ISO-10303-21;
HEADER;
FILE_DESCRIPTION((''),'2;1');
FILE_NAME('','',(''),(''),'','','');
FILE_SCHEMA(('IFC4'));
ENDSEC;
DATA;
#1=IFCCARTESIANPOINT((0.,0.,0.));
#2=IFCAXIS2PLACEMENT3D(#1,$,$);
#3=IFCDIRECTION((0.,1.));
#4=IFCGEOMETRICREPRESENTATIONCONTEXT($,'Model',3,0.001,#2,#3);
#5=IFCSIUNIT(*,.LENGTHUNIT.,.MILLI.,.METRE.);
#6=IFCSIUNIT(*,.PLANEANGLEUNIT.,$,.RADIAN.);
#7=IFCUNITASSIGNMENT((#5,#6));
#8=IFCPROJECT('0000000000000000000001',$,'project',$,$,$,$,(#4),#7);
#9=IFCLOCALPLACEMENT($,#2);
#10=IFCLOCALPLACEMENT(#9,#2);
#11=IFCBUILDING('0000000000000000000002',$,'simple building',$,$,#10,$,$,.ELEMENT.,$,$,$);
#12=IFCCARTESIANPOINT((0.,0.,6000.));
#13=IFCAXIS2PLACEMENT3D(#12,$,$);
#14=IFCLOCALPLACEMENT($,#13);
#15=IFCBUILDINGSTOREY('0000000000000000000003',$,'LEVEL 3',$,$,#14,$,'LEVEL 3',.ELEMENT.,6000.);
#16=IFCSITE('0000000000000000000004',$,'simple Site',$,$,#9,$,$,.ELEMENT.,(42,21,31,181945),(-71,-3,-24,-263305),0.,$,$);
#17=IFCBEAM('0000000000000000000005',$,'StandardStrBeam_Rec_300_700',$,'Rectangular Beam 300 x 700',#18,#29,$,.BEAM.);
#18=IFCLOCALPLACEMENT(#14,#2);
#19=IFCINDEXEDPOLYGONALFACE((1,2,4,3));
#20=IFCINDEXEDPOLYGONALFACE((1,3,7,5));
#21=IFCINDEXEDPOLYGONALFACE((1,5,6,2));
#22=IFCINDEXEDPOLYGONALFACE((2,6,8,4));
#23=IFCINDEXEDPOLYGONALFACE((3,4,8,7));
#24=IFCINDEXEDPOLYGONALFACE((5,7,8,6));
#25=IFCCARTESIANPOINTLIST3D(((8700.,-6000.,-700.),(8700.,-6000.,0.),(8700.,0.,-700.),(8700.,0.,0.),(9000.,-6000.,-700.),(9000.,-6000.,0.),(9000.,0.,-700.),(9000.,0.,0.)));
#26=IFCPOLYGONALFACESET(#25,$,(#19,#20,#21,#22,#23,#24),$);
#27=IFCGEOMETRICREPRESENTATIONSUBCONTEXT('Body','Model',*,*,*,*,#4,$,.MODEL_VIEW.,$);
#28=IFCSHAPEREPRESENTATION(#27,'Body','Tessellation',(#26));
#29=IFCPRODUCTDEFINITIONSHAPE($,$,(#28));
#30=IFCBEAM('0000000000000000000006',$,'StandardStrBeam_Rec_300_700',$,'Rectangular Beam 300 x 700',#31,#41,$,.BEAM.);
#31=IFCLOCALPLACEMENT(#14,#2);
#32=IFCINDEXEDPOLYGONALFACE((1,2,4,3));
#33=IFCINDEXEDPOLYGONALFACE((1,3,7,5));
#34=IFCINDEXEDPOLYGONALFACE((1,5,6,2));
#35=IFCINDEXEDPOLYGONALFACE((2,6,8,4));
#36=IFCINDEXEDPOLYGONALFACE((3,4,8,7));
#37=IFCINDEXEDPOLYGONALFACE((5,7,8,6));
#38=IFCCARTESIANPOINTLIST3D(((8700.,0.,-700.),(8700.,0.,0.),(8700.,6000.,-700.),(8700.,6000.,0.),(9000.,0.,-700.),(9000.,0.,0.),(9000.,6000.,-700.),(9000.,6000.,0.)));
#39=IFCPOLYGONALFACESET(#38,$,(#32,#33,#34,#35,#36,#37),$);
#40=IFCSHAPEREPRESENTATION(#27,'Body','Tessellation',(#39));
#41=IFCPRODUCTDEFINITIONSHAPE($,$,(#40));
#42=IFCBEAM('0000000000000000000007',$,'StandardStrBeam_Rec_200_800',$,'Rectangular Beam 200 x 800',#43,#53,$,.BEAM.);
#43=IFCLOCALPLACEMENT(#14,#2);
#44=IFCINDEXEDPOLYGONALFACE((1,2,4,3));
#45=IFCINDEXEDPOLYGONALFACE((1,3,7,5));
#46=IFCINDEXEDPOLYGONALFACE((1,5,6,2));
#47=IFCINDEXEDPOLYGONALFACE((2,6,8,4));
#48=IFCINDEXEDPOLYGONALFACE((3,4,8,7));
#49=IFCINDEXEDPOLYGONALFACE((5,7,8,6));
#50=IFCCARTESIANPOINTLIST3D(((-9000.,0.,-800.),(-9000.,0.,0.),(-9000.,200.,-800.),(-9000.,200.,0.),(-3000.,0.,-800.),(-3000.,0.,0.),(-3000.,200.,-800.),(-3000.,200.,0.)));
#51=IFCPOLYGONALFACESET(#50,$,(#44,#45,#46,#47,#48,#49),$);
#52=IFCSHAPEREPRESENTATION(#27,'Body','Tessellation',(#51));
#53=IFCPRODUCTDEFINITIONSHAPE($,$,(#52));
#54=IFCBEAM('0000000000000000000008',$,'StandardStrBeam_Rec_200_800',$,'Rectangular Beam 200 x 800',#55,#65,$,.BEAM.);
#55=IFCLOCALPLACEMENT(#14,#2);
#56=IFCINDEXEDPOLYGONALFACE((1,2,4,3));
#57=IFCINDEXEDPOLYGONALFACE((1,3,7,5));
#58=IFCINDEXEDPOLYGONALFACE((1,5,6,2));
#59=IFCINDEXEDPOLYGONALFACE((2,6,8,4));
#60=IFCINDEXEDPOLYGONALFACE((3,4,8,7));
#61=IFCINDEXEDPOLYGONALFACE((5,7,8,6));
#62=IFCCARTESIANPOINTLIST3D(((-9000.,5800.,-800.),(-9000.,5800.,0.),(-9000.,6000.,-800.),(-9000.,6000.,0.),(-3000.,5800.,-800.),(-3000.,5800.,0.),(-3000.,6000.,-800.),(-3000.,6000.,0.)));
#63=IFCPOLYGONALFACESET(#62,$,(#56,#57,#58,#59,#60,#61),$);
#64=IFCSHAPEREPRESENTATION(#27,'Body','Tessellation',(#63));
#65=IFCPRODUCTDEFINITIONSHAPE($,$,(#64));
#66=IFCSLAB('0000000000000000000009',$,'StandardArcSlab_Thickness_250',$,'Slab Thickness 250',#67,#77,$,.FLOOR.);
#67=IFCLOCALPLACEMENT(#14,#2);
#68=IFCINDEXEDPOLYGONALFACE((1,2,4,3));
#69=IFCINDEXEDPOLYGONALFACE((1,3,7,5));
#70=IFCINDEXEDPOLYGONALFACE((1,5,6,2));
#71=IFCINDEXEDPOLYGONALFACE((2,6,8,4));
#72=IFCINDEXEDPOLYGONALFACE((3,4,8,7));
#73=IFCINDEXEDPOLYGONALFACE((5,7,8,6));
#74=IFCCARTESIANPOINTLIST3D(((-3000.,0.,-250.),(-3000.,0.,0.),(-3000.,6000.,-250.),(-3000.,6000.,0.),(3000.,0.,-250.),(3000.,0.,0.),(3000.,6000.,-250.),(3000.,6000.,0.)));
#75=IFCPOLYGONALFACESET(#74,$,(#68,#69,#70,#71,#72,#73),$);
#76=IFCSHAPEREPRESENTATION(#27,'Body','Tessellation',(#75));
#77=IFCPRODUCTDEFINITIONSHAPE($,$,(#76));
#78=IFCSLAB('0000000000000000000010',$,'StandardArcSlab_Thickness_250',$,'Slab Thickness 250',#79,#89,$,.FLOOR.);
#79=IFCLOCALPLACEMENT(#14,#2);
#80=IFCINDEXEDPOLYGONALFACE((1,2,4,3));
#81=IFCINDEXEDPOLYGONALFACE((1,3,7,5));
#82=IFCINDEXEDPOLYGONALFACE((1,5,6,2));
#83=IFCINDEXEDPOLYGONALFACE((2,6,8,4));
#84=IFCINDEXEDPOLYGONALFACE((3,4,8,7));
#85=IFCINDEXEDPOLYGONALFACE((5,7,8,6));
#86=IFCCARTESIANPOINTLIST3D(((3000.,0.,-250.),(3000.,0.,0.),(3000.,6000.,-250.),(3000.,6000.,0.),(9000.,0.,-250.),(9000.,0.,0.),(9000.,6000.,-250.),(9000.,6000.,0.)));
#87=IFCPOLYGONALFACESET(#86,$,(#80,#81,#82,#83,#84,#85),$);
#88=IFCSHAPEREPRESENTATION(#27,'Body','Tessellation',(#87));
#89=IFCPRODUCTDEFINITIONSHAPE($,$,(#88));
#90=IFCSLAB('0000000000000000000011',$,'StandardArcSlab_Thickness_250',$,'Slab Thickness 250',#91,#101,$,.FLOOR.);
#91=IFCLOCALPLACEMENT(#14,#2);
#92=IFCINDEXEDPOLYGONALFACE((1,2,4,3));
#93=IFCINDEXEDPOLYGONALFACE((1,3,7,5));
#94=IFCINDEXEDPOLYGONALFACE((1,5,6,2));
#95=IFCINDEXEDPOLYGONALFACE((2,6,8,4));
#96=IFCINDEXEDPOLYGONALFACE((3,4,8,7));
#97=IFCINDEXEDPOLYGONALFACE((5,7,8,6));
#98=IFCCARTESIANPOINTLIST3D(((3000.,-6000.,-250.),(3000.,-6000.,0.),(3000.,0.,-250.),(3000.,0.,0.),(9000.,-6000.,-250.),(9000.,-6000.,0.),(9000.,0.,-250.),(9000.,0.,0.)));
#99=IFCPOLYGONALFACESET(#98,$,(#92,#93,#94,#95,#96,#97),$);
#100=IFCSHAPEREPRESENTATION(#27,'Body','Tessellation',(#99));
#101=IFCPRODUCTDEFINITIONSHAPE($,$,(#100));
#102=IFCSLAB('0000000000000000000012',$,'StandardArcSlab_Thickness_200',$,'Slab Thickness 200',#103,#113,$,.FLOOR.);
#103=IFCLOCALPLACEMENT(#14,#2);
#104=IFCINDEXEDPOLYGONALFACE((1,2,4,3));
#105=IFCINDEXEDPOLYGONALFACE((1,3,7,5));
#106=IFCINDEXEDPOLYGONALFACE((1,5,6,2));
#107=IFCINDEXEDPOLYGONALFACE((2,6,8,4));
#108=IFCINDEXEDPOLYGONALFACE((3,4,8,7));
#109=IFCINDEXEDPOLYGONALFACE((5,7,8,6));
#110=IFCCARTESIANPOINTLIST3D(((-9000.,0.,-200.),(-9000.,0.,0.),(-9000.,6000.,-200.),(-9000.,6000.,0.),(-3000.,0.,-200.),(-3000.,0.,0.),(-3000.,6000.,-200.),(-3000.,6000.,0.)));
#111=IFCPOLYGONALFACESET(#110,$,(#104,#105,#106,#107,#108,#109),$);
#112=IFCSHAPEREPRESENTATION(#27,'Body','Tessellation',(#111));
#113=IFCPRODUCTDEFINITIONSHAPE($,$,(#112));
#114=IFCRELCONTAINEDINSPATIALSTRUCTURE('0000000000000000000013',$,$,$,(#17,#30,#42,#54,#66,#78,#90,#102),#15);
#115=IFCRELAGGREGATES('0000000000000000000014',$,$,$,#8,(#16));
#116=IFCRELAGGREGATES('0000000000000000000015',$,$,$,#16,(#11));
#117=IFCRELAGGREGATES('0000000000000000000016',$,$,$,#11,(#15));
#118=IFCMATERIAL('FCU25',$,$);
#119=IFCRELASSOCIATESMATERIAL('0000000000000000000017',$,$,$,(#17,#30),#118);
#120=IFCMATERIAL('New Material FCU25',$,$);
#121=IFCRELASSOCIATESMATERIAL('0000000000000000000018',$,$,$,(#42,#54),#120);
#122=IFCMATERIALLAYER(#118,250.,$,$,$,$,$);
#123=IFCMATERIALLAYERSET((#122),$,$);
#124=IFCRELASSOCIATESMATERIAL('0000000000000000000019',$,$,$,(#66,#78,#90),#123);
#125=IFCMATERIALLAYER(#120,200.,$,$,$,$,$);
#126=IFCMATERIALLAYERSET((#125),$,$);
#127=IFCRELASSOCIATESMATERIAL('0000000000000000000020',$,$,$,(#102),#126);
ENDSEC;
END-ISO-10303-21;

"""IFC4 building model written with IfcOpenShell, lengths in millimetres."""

from ifc_helpers import new_model, si_unit, direction, frame, origin, origin_with_axes, origin_2d_with_axis, place, context, subcontext, project, spatial, polyline, rectangle, outline, extrude, material, layer, layer_set, layer_usage, material_profile, profile_set, profile_usage, element, save


model = new_model("IFC4")

# Units and contexts
model_context = context("Model", 3, precision=0.001, world=origin(), true_north=direction((0.0, 1.0)))
body_context = subcontext(model_context, "Body", "Model", "MODEL_VIEW")
ifc_project = project(units=[si_unit("LENGTHUNIT", "METRE", prefix="MILLI"), si_unit("PLANEANGLEUNIT", "RADIAN")], contexts=[model_context])

# Site, building, storey
site_placement = place(None, origin())
site = spatial("IfcSite", under=ifc_project, at=site_placement, Name="simple Site", CompositionType="ELEMENT", RefLatitude=(42, 21, 31, 181945), RefLongitude=(-71, -3, -24, -263305), RefElevation=0.0)
building_placement = place(site_placement, origin())
building = spatial("IfcBuilding", under=site, at=building_placement, Name="simple building", CompositionType="ELEMENT")
storey_placement = place(None, frame((0.0, 0.0, 6000.0)))
storey = spatial("IfcBuildingStorey", under=building, at=storey_placement, Name="LEVEL 3", LongName="LEVEL 3", CompositionType="ELEMENT", Elevation=6000.0)

# Beams
ifc_material_1 = material(Name="FCU25")
ifc_material_profile_1 = material_profile(ifc_material_1, rectangle(XDim=300.0, YDim=700.0, at=origin_2d_with_axis()))
ifc_profile_set_1 = profile_set([ifc_material_profile_1])
ifc_profile_usage_1 = profile_usage(ifc_profile_set_1, cardinal=9)
for number, where, z_axis, x_axis, name in (
    (1, (8850.0, -6000.0, 5650.0), (0.0, 1.0, 0.0), (1.0, 0.0, 0.0), "StandardStrBeam_Rec_300_700"),
    (2, (8850.0, 0.0, 5650.0), (0.0, 1.0, 0.0), (1.0, 0.0, 0.0), "StandardStrBeam_Rec_300_700"),
):
    element("IfcBeam", number, at=place(None, frame(where, z_axis=z_axis, x_axis=x_axis)), inside=storey, material=ifc_profile_usage_1, Name=name, ObjectType="Rectangular Beam 300 x 700", PredefinedType="BEAM", context=body_context, shape_type="SweptSolid", body=[
        extrude(rectangle(XDim=300.0, YDim=700.0, at=origin_2d_with_axis()), origin_with_axes(), (0.0, 0.0, 1.0), 6000.0),
    ])
ifc_material_2 = material(Name="New Material FCU25")
ifc_material_profile_2 = material_profile(ifc_material_2, rectangle(XDim=200.0, YDim=800.0, at=origin_2d_with_axis()))
ifc_profile_set_2 = profile_set([ifc_material_profile_2])
ifc_profile_usage_2 = profile_usage(ifc_profile_set_2, cardinal=9)
beam_1_placement = place(None, frame((-9000.0, 100.0, 5600.0), z_axis=(1.0, 0.0, 0.0), x_axis=(0.0, -1.0, 0.0)))
element("IfcBeam", 3, at=beam_1_placement, inside=storey, material=ifc_profile_usage_2, Name="StandardStrBeam_Rec_200_800", ObjectType="Rectangular Beam 200 x 800", PredefinedType="BEAM", context=body_context, shape_type="SweptSolid", body=[
    extrude(rectangle(XDim=200.0, YDim=800.0, at=origin_2d_with_axis()), origin_with_axes(), (0.0, 0.0, 1.0), 6000.0),
])
ifc_profile_usage_3 = profile_usage(ifc_profile_set_2, cardinal=7)
beam_2_placement = place(None, frame((-9000.0, 5900.0, 5600.0), z_axis=(1.0, 0.0, 0.0), x_axis=(0.0, -1.0, 0.0)))
element("IfcBeam", 4, at=beam_2_placement, inside=storey, material=ifc_profile_usage_3, Name="StandardStrBeam_Rec_200_800", ObjectType="Rectangular Beam 200 x 800", PredefinedType="BEAM", context=body_context, shape_type="SweptSolid", body=[
    extrude(rectangle(XDim=200.0, YDim=800.0, at=origin_2d_with_axis()), origin_with_axes(), (0.0, 0.0, 1.0), 6000.0),
])

# Slabs
ifc_layer_1 = layer(ifc_material_1, 250.0)
ifc_layer_set_1 = layer_set([ifc_layer_1])
ifc_layer_usage_1 = layer_usage(ifc_layer_set_1, "AXIS3", "POSITIVE", -250.0)
for number, where, z_axis, x_axis, name in (
    (5, (-3000.0, 0.0, 5750.0), (0.0, 0.0, 1.0), (1.0, 0.0, 0.0), "StandardArcSlab_Thickness_250"),
    (6, (3000.0, 0.0, 5750.0), (0.0, 0.0, 1.0), (1.0, 0.0, 0.0), "StandardArcSlab_Thickness_250"),
    (7, (3000.0, -6000.0, 5750.0), (0.0, 0.0, 1.0), (1.0, 0.0, 0.0), "StandardArcSlab_Thickness_250"),
):
    element("IfcSlab", number, at=place(None, frame(where, z_axis=z_axis, x_axis=x_axis)), inside=storey, material=ifc_layer_usage_1, Name=name, ObjectType="Slab Thickness 250", PredefinedType="FLOOR", context=body_context, shape_type="SweptSolid", body=[
        extrude(outline(polyline([(0.0, 0.0), (6000.0, 0.0), (6000.0, 6000.0), (0.0, 6000.0), (0.0, 0.0)])), origin_with_axes(), (0.0, 0.0, 1.0), 250.0),
    ])
ifc_layer_2 = layer(ifc_material_2, 200.0)
ifc_layer_set_2 = layer_set([ifc_layer_2])
ifc_layer_usage_2 = layer_usage(ifc_layer_set_2, "AXIS3", "POSITIVE", -200.0)
slab_placement = place(None, frame((-9000.0, 0.0, 5800.0), z_axis=(0.0, 0.0, 1.0), x_axis=(1.0, 0.0, 0.0)))
element("IfcSlab", 8, at=slab_placement, inside=storey, material=ifc_layer_usage_2, Name="StandardArcSlab_Thickness_200", ObjectType="Slab Thickness 200", PredefinedType="FLOOR", context=body_context, shape_type="SweptSolid", body=[
    extrude(outline(polyline([(0.0, 0.0), (6000.0, 0.0), (6000.0, 6000.0), (0.0, 6000.0), (0.0, 0.0)])), origin_with_axes(), (0.0, 0.0, 1.0), 200.0),
])

save(model, "model.ifc")
